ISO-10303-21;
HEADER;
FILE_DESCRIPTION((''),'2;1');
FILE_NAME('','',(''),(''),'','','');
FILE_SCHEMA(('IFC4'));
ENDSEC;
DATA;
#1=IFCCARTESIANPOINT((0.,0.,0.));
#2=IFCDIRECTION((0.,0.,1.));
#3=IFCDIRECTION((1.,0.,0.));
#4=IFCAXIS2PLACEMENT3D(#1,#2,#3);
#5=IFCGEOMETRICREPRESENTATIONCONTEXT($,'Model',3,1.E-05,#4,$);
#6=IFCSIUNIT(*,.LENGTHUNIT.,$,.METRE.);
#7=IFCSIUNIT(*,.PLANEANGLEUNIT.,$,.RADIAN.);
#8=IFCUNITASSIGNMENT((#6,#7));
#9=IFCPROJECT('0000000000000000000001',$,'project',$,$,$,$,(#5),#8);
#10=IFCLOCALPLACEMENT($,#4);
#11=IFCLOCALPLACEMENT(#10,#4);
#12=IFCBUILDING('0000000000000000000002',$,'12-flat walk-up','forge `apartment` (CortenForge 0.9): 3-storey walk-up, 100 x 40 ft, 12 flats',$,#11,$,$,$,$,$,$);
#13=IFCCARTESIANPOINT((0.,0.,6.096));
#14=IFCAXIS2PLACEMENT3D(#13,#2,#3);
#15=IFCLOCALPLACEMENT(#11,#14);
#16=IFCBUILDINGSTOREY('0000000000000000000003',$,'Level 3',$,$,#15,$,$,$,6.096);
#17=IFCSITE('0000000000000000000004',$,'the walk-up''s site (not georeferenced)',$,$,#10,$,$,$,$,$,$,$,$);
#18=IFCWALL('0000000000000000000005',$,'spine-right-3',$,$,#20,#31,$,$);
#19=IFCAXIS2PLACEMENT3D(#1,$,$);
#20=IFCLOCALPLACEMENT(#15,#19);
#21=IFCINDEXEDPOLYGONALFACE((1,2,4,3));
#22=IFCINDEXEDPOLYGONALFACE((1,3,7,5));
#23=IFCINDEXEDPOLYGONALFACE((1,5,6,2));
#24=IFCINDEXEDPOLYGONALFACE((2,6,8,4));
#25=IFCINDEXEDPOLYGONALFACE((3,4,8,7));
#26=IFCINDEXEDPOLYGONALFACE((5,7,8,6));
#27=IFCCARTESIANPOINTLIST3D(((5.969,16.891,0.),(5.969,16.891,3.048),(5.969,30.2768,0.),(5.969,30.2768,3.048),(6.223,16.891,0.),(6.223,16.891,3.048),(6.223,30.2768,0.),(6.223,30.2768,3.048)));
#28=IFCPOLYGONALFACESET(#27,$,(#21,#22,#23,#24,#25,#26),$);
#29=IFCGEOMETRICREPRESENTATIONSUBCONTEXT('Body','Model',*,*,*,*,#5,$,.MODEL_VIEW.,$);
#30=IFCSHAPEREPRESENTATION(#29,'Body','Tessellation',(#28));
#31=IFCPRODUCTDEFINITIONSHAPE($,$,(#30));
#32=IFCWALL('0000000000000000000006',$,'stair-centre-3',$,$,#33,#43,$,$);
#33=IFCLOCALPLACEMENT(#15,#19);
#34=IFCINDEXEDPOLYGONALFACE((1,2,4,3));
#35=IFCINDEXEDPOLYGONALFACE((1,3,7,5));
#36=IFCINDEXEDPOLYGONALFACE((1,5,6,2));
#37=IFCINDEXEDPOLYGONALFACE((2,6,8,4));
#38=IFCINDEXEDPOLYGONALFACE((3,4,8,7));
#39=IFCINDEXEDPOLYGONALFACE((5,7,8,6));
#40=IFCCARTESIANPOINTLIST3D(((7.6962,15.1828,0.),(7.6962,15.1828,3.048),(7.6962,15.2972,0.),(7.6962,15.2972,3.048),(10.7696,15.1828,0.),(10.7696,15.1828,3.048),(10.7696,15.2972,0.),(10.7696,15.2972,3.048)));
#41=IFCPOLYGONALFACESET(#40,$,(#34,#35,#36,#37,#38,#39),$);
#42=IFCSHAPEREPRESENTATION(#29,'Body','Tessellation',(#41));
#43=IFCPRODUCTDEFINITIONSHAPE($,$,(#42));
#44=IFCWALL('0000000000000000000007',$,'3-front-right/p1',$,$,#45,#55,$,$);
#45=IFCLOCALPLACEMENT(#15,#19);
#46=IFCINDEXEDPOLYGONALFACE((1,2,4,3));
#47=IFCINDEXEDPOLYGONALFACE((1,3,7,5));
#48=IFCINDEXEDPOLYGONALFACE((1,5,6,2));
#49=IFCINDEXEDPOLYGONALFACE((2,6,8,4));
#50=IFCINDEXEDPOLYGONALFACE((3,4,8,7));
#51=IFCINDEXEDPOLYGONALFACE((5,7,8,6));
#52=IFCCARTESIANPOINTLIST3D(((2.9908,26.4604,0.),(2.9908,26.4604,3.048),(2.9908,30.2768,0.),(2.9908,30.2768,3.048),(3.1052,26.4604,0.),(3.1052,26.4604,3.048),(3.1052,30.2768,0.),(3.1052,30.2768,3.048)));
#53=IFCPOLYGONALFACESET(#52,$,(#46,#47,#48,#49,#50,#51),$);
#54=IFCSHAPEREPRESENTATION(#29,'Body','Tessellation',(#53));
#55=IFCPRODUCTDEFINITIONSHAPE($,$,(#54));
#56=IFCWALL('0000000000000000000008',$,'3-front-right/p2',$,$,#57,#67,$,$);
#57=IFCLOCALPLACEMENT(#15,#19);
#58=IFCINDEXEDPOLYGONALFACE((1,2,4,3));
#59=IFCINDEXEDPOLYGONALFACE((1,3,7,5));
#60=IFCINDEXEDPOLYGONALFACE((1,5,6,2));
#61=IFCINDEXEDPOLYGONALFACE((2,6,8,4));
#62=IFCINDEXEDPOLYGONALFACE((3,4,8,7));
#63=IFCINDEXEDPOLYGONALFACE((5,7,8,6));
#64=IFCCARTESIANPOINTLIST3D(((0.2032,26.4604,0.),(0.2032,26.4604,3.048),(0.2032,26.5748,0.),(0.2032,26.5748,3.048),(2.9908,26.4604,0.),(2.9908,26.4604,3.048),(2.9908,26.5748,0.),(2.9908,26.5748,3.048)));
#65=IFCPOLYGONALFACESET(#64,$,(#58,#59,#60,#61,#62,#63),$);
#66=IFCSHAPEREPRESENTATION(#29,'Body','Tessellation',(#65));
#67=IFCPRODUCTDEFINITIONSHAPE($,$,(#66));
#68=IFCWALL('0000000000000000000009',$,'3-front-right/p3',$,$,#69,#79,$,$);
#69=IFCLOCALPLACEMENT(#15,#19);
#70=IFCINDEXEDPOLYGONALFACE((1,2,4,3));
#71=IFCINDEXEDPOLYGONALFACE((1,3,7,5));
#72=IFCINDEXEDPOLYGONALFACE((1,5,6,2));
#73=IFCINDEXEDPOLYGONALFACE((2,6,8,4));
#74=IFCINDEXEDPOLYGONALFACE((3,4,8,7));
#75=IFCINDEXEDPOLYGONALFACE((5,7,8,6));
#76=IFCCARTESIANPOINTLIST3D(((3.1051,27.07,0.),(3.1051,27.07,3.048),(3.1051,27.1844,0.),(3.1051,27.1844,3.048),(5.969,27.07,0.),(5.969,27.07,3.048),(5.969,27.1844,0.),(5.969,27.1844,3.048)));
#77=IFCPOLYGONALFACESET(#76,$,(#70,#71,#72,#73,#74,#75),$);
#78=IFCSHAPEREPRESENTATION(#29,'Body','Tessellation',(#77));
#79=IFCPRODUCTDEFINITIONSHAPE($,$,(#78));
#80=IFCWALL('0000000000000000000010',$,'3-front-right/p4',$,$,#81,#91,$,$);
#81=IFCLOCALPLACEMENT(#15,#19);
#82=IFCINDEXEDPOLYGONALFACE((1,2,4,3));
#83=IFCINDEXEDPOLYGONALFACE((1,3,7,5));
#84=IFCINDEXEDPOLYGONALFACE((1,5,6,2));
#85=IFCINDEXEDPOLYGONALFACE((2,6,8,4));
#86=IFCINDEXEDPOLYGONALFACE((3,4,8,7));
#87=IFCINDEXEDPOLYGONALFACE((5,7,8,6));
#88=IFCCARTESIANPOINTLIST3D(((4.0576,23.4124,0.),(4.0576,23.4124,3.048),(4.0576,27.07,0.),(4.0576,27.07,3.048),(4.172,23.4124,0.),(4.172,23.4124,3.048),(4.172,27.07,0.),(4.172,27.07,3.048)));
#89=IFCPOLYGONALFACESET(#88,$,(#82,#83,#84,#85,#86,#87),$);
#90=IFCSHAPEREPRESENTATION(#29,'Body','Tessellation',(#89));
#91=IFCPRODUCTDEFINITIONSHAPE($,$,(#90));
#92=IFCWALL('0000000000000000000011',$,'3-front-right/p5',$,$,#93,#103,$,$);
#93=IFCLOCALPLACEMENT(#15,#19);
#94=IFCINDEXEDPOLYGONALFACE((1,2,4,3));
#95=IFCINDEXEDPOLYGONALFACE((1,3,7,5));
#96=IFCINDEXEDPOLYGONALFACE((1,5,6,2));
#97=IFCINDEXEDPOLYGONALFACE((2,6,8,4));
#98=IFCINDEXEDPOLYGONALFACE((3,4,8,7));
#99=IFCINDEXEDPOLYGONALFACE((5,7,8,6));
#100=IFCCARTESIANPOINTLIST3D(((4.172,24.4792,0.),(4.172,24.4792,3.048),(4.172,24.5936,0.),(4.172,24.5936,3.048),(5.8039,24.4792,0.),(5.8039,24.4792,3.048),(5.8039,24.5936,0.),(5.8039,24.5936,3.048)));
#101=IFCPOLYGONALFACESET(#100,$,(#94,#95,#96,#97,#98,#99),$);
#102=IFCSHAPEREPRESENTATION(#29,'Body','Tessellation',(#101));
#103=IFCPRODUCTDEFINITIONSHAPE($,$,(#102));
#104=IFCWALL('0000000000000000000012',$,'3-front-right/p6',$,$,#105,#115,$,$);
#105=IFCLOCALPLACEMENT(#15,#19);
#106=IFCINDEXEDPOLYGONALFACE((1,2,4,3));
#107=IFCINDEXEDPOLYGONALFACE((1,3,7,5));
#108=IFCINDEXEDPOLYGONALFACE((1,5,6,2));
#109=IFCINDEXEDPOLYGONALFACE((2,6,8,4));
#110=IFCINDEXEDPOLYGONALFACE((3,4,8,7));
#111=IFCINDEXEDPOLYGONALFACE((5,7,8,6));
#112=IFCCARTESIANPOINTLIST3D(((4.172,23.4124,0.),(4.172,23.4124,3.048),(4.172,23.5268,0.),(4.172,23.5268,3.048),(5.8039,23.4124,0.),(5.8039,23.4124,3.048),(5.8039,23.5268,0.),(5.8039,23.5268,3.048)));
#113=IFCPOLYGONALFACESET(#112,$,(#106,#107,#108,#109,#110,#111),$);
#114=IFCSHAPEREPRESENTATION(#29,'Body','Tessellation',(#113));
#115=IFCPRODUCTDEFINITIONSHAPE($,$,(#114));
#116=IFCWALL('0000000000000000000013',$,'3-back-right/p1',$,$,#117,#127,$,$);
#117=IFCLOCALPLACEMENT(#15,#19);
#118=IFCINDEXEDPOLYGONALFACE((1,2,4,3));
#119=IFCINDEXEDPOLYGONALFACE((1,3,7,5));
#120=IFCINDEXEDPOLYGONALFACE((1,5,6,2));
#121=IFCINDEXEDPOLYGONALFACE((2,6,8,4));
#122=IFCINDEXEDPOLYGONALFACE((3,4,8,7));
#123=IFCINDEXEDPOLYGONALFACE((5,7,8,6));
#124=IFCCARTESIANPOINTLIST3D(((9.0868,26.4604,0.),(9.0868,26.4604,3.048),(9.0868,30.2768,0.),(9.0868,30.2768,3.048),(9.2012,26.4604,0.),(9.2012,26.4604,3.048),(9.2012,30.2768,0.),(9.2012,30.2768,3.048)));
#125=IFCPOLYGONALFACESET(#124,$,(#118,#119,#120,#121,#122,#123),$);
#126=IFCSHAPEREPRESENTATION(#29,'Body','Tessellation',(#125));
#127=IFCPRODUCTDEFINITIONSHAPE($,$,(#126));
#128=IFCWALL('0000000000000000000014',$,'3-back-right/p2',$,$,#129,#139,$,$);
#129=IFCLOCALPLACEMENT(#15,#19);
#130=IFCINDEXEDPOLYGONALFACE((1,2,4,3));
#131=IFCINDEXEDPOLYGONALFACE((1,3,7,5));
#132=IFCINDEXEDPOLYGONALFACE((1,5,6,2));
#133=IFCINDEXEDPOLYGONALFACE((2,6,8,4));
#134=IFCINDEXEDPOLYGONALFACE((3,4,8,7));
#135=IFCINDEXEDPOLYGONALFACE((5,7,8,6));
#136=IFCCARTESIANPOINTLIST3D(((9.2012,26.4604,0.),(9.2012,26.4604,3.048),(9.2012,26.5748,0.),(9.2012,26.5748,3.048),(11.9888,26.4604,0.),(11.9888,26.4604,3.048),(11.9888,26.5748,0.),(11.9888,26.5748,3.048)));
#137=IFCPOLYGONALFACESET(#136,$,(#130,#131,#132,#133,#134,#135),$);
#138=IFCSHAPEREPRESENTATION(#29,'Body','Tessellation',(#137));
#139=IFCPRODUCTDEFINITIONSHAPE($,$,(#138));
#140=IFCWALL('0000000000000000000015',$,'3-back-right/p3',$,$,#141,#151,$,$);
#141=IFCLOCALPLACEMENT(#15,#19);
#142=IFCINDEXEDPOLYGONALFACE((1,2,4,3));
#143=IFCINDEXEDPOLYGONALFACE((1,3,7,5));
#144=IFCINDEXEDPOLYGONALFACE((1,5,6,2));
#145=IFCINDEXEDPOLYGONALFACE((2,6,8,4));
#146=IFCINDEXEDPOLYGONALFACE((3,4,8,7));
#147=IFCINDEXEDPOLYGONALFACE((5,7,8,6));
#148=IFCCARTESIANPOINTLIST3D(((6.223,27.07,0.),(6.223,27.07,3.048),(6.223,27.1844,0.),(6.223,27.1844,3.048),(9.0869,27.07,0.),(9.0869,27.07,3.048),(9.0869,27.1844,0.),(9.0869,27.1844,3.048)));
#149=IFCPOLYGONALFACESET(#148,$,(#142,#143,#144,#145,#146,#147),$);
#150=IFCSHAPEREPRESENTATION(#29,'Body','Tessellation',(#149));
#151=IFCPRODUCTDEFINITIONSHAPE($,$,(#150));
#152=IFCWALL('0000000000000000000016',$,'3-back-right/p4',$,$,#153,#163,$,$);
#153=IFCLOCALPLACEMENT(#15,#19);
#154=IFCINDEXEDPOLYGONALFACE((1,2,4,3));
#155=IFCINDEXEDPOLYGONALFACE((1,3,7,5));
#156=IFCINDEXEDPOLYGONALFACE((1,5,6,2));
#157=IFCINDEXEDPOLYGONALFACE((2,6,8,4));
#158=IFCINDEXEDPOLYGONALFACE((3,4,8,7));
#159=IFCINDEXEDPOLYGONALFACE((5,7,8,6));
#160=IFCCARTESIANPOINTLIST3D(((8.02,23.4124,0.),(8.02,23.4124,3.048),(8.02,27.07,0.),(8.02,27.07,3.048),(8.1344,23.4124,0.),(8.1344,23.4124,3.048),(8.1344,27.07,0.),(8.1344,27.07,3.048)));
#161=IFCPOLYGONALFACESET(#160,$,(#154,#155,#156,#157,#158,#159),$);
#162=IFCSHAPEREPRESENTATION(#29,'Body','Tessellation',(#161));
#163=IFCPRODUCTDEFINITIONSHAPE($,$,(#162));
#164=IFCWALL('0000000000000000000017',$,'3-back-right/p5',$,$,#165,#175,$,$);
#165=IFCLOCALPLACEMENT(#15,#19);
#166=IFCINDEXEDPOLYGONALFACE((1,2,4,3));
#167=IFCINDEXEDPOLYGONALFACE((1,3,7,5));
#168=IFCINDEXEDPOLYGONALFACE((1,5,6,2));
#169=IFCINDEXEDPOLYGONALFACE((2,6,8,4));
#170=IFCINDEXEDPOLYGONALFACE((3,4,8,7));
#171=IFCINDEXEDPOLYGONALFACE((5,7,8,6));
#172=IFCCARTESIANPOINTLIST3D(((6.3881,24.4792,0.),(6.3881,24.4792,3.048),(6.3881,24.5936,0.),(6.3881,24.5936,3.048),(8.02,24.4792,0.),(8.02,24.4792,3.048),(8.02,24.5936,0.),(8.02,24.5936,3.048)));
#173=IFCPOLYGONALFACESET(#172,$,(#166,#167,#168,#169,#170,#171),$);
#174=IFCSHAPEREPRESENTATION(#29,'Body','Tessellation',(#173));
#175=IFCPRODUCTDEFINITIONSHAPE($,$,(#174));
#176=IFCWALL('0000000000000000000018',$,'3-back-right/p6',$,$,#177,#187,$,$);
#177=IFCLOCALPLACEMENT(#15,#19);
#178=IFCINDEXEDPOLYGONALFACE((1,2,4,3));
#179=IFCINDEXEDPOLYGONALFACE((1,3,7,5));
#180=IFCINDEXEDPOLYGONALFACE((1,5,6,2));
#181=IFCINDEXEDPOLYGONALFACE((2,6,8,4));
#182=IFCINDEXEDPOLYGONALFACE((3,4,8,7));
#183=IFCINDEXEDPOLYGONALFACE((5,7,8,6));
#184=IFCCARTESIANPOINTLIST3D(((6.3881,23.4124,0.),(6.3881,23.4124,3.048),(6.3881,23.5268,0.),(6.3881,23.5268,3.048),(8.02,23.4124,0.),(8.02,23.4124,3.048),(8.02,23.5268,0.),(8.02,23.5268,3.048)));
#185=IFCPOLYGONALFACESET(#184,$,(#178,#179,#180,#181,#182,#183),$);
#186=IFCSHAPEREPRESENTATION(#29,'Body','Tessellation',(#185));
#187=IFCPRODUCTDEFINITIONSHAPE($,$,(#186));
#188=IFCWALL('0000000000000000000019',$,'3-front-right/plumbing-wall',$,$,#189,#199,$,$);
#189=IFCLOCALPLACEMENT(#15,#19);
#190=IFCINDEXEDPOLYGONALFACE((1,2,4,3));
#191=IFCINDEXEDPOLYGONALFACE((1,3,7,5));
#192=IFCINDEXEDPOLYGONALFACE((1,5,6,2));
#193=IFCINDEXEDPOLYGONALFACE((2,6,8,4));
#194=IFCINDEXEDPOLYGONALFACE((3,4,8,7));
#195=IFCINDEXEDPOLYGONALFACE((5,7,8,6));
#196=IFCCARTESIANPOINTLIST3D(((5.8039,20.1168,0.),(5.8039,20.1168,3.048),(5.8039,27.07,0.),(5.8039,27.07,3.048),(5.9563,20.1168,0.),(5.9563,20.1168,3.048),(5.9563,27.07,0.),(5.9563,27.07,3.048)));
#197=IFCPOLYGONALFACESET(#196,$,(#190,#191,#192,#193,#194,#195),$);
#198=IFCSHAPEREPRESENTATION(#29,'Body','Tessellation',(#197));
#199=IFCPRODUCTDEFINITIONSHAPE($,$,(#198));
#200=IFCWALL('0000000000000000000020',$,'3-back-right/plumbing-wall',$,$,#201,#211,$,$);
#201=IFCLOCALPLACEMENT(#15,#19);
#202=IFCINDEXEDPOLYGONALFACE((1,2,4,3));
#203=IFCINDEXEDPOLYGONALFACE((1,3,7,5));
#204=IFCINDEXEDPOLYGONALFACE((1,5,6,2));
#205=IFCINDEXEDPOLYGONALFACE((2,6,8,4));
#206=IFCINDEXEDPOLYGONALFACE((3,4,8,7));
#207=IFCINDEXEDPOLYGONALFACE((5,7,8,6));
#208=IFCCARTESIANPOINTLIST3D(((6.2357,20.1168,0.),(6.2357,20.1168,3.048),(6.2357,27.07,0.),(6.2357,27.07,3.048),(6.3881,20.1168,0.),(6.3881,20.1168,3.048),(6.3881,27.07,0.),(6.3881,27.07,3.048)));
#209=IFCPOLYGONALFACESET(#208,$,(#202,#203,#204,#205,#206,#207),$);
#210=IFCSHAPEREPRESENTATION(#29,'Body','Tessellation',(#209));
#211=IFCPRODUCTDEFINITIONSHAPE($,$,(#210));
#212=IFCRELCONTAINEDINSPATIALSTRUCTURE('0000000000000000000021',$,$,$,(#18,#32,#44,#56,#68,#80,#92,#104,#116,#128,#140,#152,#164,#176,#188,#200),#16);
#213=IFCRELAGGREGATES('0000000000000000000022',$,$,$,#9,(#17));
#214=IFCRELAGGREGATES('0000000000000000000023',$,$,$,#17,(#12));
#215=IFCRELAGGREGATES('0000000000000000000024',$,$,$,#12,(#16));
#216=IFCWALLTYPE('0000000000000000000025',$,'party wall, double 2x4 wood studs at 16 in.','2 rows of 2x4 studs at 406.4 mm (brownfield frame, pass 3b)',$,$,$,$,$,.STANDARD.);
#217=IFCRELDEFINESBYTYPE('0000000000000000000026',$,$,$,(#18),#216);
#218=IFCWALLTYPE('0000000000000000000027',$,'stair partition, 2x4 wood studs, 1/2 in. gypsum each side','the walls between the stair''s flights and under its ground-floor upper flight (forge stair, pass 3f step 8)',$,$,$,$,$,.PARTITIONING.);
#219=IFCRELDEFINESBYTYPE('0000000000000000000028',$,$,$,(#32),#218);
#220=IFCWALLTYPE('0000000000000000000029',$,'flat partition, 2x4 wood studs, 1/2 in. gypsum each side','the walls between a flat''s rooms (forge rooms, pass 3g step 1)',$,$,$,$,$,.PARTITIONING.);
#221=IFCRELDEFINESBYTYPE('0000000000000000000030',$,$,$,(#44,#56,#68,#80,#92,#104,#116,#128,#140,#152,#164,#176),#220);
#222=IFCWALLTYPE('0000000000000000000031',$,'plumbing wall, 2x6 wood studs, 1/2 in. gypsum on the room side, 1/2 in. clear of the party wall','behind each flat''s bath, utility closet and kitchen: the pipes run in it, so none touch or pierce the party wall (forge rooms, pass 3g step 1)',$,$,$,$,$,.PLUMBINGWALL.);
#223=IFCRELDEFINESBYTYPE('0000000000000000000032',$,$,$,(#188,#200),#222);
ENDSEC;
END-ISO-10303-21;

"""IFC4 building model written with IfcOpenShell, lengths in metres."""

from ifc_helpers import new_model, si_unit, frame, frame_2d, origin, origin_with_axes, place, context, subcontext, project, spatial, rectangle, extrude, type_object, element, save


model = new_model("IFC4")

# Units and contexts
model_context = context("Model", 3, precision=1e-05, world=origin_with_axes())
body_context = subcontext(model_context, "Body", "Model", "MODEL_VIEW")
ifc_project = project(units=[si_unit("LENGTHUNIT", "METRE"), si_unit("PLANEANGLEUNIT", "RADIAN")], contexts=[model_context])

# Site, building, storey
site_placement = place(None, origin_with_axes())
site = spatial("IfcSite", under=ifc_project, at=site_placement, Name="the walk-up's site (not georeferenced)")
building_placement = place(site_placement, origin_with_axes())
building = spatial("IfcBuilding", under=site, at=building_placement, Name="12-flat walk-up", Description="forge `apartment` (CortenForge 0.9): 3-storey walk-up, 100 x 40 ft, 12 flats")
storey_placement = place(building_placement, frame((0.0, 0.0, 6.096), z_axis=(0.0, 0.0, 1.0), x_axis=(1.0, 0.0, 0.0)))
storey = spatial("IfcBuildingStorey", under=building, at=storey_placement, Name="Level 3", Elevation=6.096)

# Walls
wall_type_1 = type_object("IfcWallType", Name="party wall, double 2x4 wood studs at 16 in.", Description="2 rows of 2x4 studs at 406.4 mm (brownfield frame, pass 3b)", PredefinedType="STANDARD")
wall_1_placement = place(storey_placement, frame((5.969, 16.891, 0.0), z_axis=(0.0, 0.0, 1.0), x_axis=(1.0, 0.0, 0.0)))
element("IfcWall", 1, at=wall_1_placement, inside=storey, type_object=wall_type_1, Name="spine-right-3", context=body_context, shape_type="SweptSolid", body=[
    extrude(rectangle(XDim=0.254, YDim=13.3858, at=frame_2d((0.127, 6.6929))), origin(), (0.0, 0.0, 1.0), 3.048),
])
wall_type_2 = type_object("IfcWallType", Name="stair partition, 2x4 wood studs, 1/2 in. gypsum each side", Description="the walls between the stair's flights and under its ground-floor upper flight (forge stair, pass 3f step 8)", PredefinedType="PARTITIONING")
wall_2_placement = place(storey_placement, frame((7.6962, 15.1829, 0.0), z_axis=(0.0, 0.0, 1.0), x_axis=(1.0, 0.0, 0.0)))
element("IfcWall", 2, at=wall_2_placement, inside=storey, type_object=wall_type_2, Name="stair-centre-3", context=body_context, shape_type="SweptSolid", body=[
    extrude(rectangle(XDim=3.0734, YDim=0.1143, at=frame_2d((1.5367, 0.0572))), origin(), (0.0, 0.0, 1.0), 3.048),
])
wall_type_3 = type_object("IfcWallType", Name="flat partition, 2x4 wood studs, 1/2 in. gypsum each side", Description="the walls between a flat's rooms (forge rooms, pass 3g step 1)", PredefinedType="PARTITIONING")
wall_3_placement = place(storey_placement, frame((2.9909, 26.4605, 0.0), z_axis=(0.0, 0.0, 1.0), x_axis=(1.0, 0.0, 0.0)))
element("IfcWall", 3, at=wall_3_placement, inside=storey, type_object=wall_type_3, Name="3-front-right/p1", context=body_context, shape_type="SweptSolid", body=[
    extrude(rectangle(XDim=0.1143, YDim=3.8163, at=frame_2d((0.0572, 1.9082))), origin(), (0.0, 0.0, 1.0), 3.048),
])
wall_4_placement = place(storey_placement, frame((0.2032, 26.4605, 0.0), z_axis=(0.0, 0.0, 1.0), x_axis=(1.0, 0.0, 0.0)))
element("IfcWall", 4, at=wall_4_placement, inside=storey, type_object=wall_type_3, Name="3-front-right/p2", context=body_context, shape_type="SweptSolid", body=[
    extrude(rectangle(XDim=2.7877, YDim=0.1143, at=frame_2d((1.3938, 0.0572))), origin(), (0.0, 0.0, 1.0), 3.048),
])
wall_5_placement = place(storey_placement, frame((3.1051, 27.07, 0.0), z_axis=(0.0, 0.0, 1.0), x_axis=(1.0, 0.0, 0.0)))
element("IfcWall", 5, at=wall_5_placement, inside=storey, type_object=wall_type_3, Name="3-front-right/p3", context=body_context, shape_type="SweptSolid", body=[
    extrude(rectangle(XDim=2.8639, YDim=0.1143, at=frame_2d((1.4319, 0.0572))), origin(), (0.0, 0.0, 1.0), 3.048),
])
wall_6_placement = place(storey_placement, frame((4.0576, 23.4124, 0.0), z_axis=(0.0, 0.0, 1.0), x_axis=(1.0, 0.0, 0.0)))
element("IfcWall", 6, at=wall_6_placement, inside=storey, type_object=wall_type_3, Name="3-front-right/p4", context=body_context, shape_type="SweptSolid", body=[
    extrude(rectangle(XDim=0.1143, YDim=3.6576, at=frame_2d((0.0572, 1.8288))), origin(), (0.0, 0.0, 1.0), 3.048),
])
for number, where, z_axis, x_axis, name in (
    (7, (4.1719, 24.4793, 0.0), (0.0, 0.0, 1.0), (1.0, 0.0, 0.0), "3-front-right/p5"),
    (8, (4.1719, 23.4124, 0.0), (0.0, 0.0, 1.0), (1.0, 0.0, 0.0), "3-front-right/p6"),
):
    element("IfcWall", number, at=place(storey_placement, frame(where, z_axis=z_axis, x_axis=x_axis)), inside=storey, type_object=wall_type_3, Name=name, context=body_context, shape_type="SweptSolid", body=[
        extrude(rectangle(XDim=1.6319, YDim=0.1143, at=frame_2d((0.816, 0.0572))), origin(), (0.0, 0.0, 1.0), 3.048),
    ])
wall_7_placement = place(storey_placement, frame((9.0869, 26.4605, 0.0), z_axis=(0.0, 0.0, 1.0), x_axis=(1.0, 0.0, 0.0)))
element("IfcWall", 9, at=wall_7_placement, inside=storey, type_object=wall_type_3, Name="3-back-right/p1", context=body_context, shape_type="SweptSolid", body=[
    extrude(rectangle(XDim=0.1143, YDim=3.8163, at=frame_2d((0.0572, 1.9082))), origin(), (0.0, 0.0, 1.0), 3.048),
])
wall_8_placement = place(storey_placement, frame((9.2012, 26.4605, 0.0), z_axis=(0.0, 0.0, 1.0), x_axis=(1.0, 0.0, 0.0)))
element("IfcWall", 10, at=wall_8_placement, inside=storey, type_object=wall_type_3, Name="3-back-right/p2", context=body_context, shape_type="SweptSolid", body=[
    extrude(rectangle(XDim=2.7876, YDim=0.1143, at=frame_2d((1.3938, 0.0572))), origin(), (0.0, 0.0, 1.0), 3.048),
])
wall_9_placement = place(storey_placement, frame((6.223, 27.07, 0.0), z_axis=(0.0, 0.0, 1.0), x_axis=(1.0, 0.0, 0.0)))
element("IfcWall", 11, at=wall_9_placement, inside=storey, type_object=wall_type_3, Name="3-back-right/p3", context=body_context, shape_type="SweptSolid", body=[
    extrude(rectangle(XDim=2.8639, YDim=0.1143, at=frame_2d((1.4319, 0.0572))), origin(), (0.0, 0.0, 1.0), 3.048),
])
wall_10_placement = place(storey_placement, frame((8.02, 23.4124, 0.0), z_axis=(0.0, 0.0, 1.0), x_axis=(1.0, 0.0, 0.0)))
element("IfcWall", 12, at=wall_10_placement, inside=storey, type_object=wall_type_3, Name="3-back-right/p4", context=body_context, shape_type="SweptSolid", body=[
    extrude(rectangle(XDim=0.1143, YDim=3.6576, at=frame_2d((0.0572, 1.8288))), origin(), (0.0, 0.0, 1.0), 3.048),
])
for number, where, z_axis, x_axis, name in (
    (13, (6.3881, 24.4793, 0.0), (0.0, 0.0, 1.0), (1.0, 0.0, 0.0), "3-back-right/p5"),
    (14, (6.3881, 23.4124, 0.0), (0.0, 0.0, 1.0), (1.0, 0.0, 0.0), "3-back-right/p6"),
):
    element("IfcWall", number, at=place(storey_placement, frame(where, z_axis=z_axis, x_axis=x_axis)), inside=storey, type_object=wall_type_3, Name=name, context=body_context, shape_type="SweptSolid", body=[
        extrude(rectangle(XDim=1.6319, YDim=0.1143, at=frame_2d((0.816, 0.0572))), origin(), (0.0, 0.0, 1.0), 3.048),
    ])
wall_type_4 = type_object("IfcWallType", Name="plumbing wall, 2x6 wood studs, 1/2 in. gypsum on the room side, 1/2 in. clear of the party wall", Description="behind each flat's bath, utility closet and kitchen: the pipes run in it, so none touch or pierce the party wall (forge rooms, pass 3g step 1)", PredefinedType="PLUMBINGWALL")
for number, where, z_axis, x_axis, name in (
    (15, (5.8039, 20.1168, 0.0), (0.0, 0.0, 1.0), (1.0, 0.0, 0.0), "3-front-right/plumbing-wall"),
    (16, (6.2357, 20.1168, 0.0), (0.0, 0.0, 1.0), (1.0, 0.0, 0.0), "3-back-right/plumbing-wall"),
):
    element("IfcWall", number, at=place(storey_placement, frame(where, z_axis=z_axis, x_axis=x_axis)), inside=storey, type_object=wall_type_4, Name=name, context=body_context, shape_type="SweptSolid", body=[
        extrude(rectangle(XDim=0.1524, YDim=6.9532, at=frame_2d((0.0762, 3.4766))), origin(), (0.0, 0.0, 1.0), 3.048),
    ])

save(model, "model.ifc")
